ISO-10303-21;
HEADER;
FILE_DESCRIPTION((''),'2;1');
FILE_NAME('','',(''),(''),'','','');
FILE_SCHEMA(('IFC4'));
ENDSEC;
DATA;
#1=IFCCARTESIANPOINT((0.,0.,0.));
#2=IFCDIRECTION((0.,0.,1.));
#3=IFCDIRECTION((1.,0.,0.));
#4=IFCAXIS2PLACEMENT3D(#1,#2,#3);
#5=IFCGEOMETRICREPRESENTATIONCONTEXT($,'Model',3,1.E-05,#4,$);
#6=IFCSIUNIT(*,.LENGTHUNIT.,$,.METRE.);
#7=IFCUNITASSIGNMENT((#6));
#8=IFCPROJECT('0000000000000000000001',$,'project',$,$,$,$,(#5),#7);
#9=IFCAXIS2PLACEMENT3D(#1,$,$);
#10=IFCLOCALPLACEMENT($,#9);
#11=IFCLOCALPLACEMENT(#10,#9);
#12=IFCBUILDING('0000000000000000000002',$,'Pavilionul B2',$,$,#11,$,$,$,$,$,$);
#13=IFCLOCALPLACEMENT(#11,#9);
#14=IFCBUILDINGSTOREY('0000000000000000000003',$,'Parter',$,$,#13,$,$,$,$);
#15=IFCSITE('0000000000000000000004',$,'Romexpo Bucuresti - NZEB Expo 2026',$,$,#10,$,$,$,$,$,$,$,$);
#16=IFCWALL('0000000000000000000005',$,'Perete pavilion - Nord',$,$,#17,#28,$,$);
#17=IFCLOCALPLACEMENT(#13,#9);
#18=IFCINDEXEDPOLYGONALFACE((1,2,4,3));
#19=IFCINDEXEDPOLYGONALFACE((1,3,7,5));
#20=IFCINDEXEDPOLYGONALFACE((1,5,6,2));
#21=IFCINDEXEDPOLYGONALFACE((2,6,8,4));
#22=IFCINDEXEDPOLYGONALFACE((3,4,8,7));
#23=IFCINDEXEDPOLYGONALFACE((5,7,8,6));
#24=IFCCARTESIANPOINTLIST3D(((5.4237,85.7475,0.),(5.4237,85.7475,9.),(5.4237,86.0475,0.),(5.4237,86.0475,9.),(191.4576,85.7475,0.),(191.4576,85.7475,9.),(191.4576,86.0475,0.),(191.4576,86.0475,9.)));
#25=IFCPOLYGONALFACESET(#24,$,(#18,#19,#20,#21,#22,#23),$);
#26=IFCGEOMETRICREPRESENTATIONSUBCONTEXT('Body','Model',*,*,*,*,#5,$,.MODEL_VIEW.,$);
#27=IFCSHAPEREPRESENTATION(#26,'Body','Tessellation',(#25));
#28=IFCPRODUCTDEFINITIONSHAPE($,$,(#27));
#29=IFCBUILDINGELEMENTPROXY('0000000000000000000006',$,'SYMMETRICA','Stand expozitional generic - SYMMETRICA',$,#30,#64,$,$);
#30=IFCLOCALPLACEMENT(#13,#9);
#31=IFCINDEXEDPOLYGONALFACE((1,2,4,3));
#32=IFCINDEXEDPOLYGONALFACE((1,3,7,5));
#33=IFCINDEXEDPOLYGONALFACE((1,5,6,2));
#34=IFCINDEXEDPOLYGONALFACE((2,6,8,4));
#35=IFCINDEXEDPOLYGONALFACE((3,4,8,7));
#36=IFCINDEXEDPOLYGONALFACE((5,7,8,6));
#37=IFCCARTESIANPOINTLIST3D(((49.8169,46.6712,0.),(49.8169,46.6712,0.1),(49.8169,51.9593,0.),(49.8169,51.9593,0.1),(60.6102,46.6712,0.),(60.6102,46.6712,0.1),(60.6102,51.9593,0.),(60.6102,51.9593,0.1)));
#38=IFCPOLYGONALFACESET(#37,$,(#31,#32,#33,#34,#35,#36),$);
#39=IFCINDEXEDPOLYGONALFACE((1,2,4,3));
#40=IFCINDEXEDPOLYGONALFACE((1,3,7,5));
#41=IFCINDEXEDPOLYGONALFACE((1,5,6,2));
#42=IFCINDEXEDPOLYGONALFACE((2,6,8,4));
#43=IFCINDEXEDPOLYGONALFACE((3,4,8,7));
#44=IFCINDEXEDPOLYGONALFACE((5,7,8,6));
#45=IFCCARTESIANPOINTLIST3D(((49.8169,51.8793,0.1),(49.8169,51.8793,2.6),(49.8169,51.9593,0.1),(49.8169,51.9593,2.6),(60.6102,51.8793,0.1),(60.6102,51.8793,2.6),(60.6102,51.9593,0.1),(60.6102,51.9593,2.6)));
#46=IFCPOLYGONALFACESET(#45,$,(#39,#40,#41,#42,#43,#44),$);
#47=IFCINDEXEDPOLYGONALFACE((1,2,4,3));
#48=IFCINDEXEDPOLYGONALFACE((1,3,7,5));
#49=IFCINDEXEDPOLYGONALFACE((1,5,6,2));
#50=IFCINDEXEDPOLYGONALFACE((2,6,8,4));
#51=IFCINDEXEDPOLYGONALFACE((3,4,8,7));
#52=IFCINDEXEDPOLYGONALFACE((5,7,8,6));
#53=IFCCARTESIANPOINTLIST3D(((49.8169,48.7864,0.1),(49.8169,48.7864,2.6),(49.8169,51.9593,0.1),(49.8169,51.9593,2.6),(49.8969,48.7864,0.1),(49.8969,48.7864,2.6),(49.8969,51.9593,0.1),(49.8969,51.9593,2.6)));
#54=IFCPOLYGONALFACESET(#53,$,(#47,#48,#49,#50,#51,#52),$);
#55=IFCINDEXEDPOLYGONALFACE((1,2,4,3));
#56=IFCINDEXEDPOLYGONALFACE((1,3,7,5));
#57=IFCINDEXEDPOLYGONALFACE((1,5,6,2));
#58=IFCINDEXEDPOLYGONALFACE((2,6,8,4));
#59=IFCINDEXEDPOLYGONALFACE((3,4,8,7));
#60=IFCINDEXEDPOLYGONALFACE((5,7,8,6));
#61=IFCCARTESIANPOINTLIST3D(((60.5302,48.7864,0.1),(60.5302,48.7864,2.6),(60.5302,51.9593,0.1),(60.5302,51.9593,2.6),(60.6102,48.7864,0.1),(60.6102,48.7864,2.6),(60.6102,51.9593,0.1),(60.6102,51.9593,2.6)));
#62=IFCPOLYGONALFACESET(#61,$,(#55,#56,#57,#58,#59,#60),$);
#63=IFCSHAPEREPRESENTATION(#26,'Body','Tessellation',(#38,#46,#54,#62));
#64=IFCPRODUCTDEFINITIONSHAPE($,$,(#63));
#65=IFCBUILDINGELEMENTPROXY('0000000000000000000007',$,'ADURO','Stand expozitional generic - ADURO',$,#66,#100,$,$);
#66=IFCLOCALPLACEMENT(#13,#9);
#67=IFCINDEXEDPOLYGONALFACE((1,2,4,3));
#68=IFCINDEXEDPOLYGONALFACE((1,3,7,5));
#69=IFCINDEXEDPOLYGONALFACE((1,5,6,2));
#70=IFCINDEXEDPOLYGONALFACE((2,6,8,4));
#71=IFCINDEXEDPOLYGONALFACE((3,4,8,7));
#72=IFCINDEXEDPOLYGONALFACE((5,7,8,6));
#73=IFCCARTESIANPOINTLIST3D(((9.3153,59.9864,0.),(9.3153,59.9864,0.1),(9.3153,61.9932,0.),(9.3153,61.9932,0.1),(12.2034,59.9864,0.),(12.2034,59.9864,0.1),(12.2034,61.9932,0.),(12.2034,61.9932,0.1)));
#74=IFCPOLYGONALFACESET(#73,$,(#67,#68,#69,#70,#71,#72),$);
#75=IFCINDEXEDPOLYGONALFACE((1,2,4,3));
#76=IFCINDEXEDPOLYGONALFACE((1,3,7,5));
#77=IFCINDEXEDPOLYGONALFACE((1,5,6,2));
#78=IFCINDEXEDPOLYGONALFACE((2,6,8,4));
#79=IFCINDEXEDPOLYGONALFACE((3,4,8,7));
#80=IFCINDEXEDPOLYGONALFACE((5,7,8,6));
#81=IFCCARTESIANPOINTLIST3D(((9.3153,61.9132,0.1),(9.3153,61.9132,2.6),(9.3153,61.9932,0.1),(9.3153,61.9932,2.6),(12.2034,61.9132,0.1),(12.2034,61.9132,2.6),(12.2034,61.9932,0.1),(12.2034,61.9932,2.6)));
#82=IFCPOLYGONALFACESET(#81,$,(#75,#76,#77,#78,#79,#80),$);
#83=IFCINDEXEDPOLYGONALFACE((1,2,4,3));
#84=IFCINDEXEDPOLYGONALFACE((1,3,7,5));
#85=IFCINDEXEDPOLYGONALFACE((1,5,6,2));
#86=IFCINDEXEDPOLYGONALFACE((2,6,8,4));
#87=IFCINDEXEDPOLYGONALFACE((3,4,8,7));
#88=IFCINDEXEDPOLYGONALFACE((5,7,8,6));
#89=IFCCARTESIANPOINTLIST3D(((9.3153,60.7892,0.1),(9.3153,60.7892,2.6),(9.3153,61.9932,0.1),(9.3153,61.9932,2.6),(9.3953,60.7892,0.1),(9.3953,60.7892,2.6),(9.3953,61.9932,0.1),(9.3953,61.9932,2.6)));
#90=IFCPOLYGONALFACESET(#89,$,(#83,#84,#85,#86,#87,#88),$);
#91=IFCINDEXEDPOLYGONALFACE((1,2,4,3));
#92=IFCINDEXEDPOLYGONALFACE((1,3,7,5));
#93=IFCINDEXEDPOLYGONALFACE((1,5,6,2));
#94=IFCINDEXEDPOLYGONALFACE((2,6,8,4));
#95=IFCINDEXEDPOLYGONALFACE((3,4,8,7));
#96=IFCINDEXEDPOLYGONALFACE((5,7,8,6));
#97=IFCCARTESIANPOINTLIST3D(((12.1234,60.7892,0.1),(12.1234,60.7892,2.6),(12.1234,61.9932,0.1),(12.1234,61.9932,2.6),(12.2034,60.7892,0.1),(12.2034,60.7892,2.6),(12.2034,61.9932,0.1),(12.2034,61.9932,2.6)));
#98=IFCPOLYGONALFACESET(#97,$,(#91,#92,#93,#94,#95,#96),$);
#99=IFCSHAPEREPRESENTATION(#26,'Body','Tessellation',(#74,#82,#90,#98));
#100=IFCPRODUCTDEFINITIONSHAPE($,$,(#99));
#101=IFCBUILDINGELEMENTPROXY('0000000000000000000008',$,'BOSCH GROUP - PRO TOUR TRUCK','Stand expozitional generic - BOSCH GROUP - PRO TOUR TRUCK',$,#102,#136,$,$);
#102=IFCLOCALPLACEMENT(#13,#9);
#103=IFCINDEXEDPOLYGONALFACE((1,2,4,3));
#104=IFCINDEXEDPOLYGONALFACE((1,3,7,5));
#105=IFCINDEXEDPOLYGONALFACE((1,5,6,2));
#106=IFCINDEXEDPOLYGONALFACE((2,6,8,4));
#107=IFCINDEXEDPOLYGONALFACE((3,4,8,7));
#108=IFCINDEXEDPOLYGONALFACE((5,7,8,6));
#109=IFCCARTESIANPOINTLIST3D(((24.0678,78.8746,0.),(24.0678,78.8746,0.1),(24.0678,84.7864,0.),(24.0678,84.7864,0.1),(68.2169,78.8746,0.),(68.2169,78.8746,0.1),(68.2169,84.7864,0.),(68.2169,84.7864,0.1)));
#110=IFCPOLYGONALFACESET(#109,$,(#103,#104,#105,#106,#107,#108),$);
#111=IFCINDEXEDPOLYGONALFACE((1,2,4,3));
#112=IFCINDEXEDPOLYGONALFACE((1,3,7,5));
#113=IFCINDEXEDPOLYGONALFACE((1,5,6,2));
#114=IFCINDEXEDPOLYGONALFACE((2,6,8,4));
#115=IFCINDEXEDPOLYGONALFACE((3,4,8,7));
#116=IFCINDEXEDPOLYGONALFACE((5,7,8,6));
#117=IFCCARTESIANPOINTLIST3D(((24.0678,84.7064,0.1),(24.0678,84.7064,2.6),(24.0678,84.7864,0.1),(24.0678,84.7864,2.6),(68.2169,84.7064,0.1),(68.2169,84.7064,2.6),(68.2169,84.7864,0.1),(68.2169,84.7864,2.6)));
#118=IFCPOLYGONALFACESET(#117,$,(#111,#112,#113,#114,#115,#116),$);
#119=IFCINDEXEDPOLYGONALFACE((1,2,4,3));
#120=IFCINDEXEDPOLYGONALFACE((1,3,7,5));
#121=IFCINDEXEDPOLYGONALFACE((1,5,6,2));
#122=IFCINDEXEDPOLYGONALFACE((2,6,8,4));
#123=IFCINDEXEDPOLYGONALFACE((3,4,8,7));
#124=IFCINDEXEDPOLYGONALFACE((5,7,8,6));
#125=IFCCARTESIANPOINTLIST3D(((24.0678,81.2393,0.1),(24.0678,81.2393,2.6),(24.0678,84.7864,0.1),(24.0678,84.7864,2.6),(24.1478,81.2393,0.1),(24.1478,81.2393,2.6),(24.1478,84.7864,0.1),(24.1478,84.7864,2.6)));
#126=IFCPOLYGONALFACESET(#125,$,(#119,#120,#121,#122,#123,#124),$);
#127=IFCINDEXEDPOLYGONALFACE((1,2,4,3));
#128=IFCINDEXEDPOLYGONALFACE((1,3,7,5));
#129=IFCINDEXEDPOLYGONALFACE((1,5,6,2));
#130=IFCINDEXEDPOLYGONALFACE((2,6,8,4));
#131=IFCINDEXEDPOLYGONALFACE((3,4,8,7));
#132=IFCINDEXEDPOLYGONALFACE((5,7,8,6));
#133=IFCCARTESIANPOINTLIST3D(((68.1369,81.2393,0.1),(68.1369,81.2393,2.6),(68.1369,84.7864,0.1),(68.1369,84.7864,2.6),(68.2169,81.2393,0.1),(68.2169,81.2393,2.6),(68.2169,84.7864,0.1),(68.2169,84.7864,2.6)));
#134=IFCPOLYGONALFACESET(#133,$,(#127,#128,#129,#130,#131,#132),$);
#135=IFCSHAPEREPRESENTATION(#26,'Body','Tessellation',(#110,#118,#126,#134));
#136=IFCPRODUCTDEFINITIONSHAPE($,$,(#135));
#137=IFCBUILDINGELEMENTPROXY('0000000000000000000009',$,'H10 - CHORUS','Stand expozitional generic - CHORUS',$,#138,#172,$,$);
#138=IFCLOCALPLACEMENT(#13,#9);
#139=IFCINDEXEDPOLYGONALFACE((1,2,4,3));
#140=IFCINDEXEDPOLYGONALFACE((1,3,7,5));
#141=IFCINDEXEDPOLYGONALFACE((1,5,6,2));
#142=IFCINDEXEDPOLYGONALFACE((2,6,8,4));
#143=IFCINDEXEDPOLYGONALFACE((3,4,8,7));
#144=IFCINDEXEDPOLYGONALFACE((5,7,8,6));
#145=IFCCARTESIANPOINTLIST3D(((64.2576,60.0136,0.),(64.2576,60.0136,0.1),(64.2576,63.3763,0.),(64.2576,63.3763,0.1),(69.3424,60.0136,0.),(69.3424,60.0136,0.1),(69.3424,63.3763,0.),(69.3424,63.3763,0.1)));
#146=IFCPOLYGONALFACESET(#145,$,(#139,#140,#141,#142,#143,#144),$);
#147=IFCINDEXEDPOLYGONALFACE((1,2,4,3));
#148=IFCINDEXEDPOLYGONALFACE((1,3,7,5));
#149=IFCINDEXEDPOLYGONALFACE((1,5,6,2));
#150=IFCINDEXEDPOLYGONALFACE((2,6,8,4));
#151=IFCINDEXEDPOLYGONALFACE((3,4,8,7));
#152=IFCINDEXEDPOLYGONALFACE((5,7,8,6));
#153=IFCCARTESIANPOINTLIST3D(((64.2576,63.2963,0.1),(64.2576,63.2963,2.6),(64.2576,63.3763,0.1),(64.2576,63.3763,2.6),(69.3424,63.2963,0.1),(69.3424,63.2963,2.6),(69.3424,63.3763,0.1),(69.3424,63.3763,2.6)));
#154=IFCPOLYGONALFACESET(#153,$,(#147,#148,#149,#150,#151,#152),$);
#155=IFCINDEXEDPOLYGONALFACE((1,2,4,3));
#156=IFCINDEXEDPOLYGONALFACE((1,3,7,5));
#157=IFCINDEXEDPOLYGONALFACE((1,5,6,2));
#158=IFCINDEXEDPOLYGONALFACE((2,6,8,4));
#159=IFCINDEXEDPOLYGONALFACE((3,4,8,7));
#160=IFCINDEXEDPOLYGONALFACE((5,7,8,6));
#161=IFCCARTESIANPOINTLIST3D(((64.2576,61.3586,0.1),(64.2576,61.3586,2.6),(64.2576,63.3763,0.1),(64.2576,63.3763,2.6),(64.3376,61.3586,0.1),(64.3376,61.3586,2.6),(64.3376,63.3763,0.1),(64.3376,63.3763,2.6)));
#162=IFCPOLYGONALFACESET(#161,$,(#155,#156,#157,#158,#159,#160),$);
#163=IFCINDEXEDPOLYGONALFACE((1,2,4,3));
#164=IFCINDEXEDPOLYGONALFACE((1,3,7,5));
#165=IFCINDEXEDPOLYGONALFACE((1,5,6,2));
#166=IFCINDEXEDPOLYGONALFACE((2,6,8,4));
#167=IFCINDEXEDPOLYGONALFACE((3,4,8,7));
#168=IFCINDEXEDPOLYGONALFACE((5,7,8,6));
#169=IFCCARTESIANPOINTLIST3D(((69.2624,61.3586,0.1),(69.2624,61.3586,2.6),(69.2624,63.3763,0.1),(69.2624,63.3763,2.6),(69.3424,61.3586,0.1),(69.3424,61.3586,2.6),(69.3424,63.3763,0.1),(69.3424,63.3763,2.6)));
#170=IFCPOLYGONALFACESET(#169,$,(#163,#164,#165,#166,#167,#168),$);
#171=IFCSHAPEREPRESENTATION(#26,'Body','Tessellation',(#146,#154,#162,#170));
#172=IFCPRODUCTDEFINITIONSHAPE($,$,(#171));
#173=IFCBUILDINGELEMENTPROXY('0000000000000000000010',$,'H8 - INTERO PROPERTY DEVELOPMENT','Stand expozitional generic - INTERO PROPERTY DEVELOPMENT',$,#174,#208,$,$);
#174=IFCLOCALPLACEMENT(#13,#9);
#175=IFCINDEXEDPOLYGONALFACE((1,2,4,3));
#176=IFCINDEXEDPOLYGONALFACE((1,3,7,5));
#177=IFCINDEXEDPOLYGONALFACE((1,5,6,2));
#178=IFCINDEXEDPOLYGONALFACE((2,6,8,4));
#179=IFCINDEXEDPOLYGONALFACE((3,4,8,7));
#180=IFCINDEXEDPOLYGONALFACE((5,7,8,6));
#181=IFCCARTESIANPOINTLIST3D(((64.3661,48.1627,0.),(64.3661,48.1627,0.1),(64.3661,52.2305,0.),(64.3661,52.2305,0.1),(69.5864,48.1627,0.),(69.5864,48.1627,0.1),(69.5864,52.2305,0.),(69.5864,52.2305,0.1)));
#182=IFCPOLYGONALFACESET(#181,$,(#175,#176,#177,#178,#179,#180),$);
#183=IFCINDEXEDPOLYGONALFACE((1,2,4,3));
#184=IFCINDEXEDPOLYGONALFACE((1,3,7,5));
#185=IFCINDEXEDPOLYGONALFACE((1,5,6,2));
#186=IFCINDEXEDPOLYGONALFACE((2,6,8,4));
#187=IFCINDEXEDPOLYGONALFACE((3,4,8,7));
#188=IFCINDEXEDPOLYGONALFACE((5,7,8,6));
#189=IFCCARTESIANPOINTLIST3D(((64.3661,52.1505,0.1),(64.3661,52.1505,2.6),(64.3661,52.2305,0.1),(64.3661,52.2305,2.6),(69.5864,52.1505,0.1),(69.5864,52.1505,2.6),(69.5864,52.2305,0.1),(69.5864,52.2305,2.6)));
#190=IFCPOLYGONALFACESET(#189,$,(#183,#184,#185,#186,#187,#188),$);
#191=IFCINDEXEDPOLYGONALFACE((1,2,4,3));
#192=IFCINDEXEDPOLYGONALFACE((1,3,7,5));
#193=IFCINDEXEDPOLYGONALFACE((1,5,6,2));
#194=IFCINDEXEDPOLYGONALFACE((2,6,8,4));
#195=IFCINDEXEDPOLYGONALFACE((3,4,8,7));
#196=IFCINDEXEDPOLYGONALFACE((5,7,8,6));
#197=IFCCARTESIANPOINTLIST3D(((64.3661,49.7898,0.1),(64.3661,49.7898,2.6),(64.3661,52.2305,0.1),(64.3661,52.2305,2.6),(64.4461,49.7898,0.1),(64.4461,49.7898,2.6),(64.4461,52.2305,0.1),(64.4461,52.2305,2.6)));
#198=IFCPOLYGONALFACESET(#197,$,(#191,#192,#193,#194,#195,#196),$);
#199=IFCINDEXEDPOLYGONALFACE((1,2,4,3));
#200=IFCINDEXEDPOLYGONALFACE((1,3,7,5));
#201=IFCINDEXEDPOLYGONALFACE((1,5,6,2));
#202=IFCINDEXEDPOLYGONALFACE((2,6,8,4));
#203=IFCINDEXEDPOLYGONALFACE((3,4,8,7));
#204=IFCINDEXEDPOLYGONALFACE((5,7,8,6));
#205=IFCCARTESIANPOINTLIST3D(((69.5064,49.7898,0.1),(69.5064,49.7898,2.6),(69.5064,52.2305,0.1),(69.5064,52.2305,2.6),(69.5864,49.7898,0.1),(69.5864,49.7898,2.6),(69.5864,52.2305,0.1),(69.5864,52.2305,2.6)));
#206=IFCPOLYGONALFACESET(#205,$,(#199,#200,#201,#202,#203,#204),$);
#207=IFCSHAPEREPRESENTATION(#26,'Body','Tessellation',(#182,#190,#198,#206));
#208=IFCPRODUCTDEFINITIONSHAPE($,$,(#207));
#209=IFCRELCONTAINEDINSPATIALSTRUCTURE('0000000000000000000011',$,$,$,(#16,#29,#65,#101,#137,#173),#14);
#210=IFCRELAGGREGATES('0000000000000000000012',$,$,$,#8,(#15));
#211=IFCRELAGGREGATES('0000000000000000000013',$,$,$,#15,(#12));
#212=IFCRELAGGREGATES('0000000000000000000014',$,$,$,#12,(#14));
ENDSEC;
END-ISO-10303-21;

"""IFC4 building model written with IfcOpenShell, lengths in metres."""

from ifc_helpers import new_model, si_unit, frame, frame_2d, origin, origin_with_axes, place, context, subcontext, project, spatial, rectangle, extrude, element, save


model = new_model("IFC4")

# Units and contexts
model_context = context("Model", 3, precision=1e-05, world=origin_with_axes())
body_context = subcontext(model_context, "Body", "Model", "MODEL_VIEW")
ifc_project = project(units=[si_unit("LENGTHUNIT", "METRE")], contexts=[model_context])

# Site, building, storey
site_placement = place(None, origin())
site = spatial("IfcSite", under=ifc_project, at=site_placement, Name="Romexpo Bucuresti - NZEB Expo 2026")
building_placement = place(site_placement, origin())
building = spatial("IfcBuilding", under=site, at=building_placement, Name="Pavilionul B2")
storey_placement = place(building_placement, origin())
storey = spatial("IfcBuildingStorey", under=building, at=storey_placement, Name="Parter")

# Wall
wall_placement = place(storey_placement, frame((5.4237, 85.7475, 0.0), z_axis=(0.0, 0.0, 1.0), x_axis=(1.0, 0.0, 0.0)))
element("IfcWall", 1, at=wall_placement, inside=storey, Name="Perete pavilion - Nord", context=body_context, shape_type="SweptSolid", body=[
    extrude(rectangle(XDim=186.0339, YDim=0.3, at=frame_2d((93.0169, 0.15))), origin(), (0.0, 0.0, 1.0), 9.0),
])

# Building element proxies
proxy_1_placement = place(storey_placement, frame((49.8169, 46.6712, 0.0), z_axis=(0.0, 0.0, 1.0), x_axis=(1.0, 0.0, 0.0)))
element("IfcBuildingElementProxy", 2, at=proxy_1_placement, inside=storey, Name="SYMMETRICA", Description="Stand expozitional generic - SYMMETRICA", context=body_context, shape_type="SweptSolid", body=[
    extrude(rectangle(XDim=10.7932, YDim=5.2881, at=frame_2d((5.3966, 2.6441))), origin(), (0.0, 0.0, 1.0), 0.1),
    extrude(rectangle(XDim=10.7932, YDim=0.08, at=frame_2d((5.3966, 5.2481))), frame((0.0, 0.0, 0.1)), (0.0, 0.0, 1.0), 2.5),
    extrude(rectangle(XDim=0.08, YDim=3.1729, at=frame_2d((0.04, 3.7017))), frame((0.0, 0.0, 0.1)), (0.0, 0.0, 1.0), 2.5),
    extrude(rectangle(XDim=0.08, YDim=3.1729, at=frame_2d((10.7532, 3.7017))), frame((0.0, 0.0, 0.1)), (0.0, 0.0, 1.0), 2.5),
])
proxy_2_placement = place(storey_placement, frame((9.3153, 59.9864, 0.0), z_axis=(0.0, 0.0, 1.0), x_axis=(1.0, 0.0, 0.0)))
element("IfcBuildingElementProxy", 3, at=proxy_2_placement, inside=storey, Name="ADURO", Description="Stand expozitional generic - ADURO", context=body_context, shape_type="SweptSolid", body=[
    extrude(rectangle(XDim=2.8881, YDim=2.0068, at=frame_2d((1.4441, 1.0034))), origin(), (0.0, 0.0, 1.0), 0.1),
    extrude(rectangle(XDim=2.8881, YDim=0.08, at=frame_2d((1.4441, 1.9668))), frame((0.0, 0.0, 0.1)), (0.0, 0.0, 1.0), 2.5),
    extrude(rectangle(XDim=0.08, YDim=1.2041, at=frame_2d((0.04, 1.4047))), frame((0.0, 0.0, 0.1)), (0.0, 0.0, 1.0), 2.5),
    extrude(rectangle(XDim=0.08, YDim=1.2041, at=frame_2d((2.8481, 1.4047))), frame((0.0, 0.0, 0.1)), (0.0, 0.0, 1.0), 2.5),
])
proxy_3_placement = place(storey_placement, frame((24.0678, 78.8746, 0.0), z_axis=(0.0, 0.0, 1.0), x_axis=(1.0, 0.0, 0.0)))
element("IfcBuildingElementProxy", 4, at=proxy_3_placement, inside=storey, Name="BOSCH GROUP - PRO TOUR TRUCK", Description="Stand expozitional generic - BOSCH GROUP - PRO TOUR TRUCK", context=body_context, shape_type="SweptSolid", body=[
    extrude(rectangle(XDim=44.1492, YDim=5.9119, at=frame_2d((22.0746, 2.9559))), origin(), (0.0, 0.0, 1.0), 0.1),
    extrude(rectangle(XDim=44.1492, YDim=0.08, at=frame_2d((22.0746, 5.8719))), frame((0.0, 0.0, 0.1)), (0.0, 0.0, 1.0), 2.5),
    extrude(rectangle(XDim=0.08, YDim=3.5471, at=frame_2d((0.04, 4.1383))), frame((0.0, 0.0, 0.1)), (0.0, 0.0, 1.0), 2.5),
    extrude(rectangle(XDim=0.08, YDim=3.5471, at=frame_2d((44.1092, 4.1383))), frame((0.0, 0.0, 0.1)), (0.0, 0.0, 1.0), 2.5),
])
proxy_4_placement = place(storey_placement, frame((64.2576, 60.0136, 0.0), z_axis=(0.0, 0.0, 1.0), x_axis=(1.0, 0.0, 0.0)))
element("IfcBuildingElementProxy", 5, at=proxy_4_placement, inside=storey, Name="H10 - CHORUS", Description="Stand expozitional generic - CHORUS", context=body_context, shape_type="SweptSolid", body=[
    extrude(rectangle(XDim=5.0847, YDim=3.3627, at=frame_2d((2.5424, 1.6814))), origin(), (0.0, 0.0, 1.0), 0.1),
    extrude(rectangle(XDim=5.0847, YDim=0.08, at=frame_2d((2.5424, 3.3227))), frame((0.0, 0.0, 0.1)), (0.0, 0.0, 1.0), 2.5),
    extrude(rectangle(XDim=0.08, YDim=2.0176, at=frame_2d((0.04, 2.3539))), frame((0.0, 0.0, 0.1)), (0.0, 0.0, 1.0), 2.5),
    extrude(rectangle(XDim=0.08, YDim=2.0176, at=frame_2d((5.0447, 2.3539))), frame((0.0, 0.0, 0.1)), (0.0, 0.0, 1.0), 2.5),
])
proxy_5_placement = place(storey_placement, frame((64.3661, 48.1627, 0.0), z_axis=(0.0, 0.0, 1.0), x_axis=(1.0, 0.0, 0.0)))
element("IfcBuildingElementProxy", 6, at=proxy_5_placement, inside=storey, Name="H8 - INTERO PROPERTY DEVELOPMENT", Description="Stand expozitional generic - INTERO PROPERTY DEVELOPMENT", context=body_context, shape_type="SweptSolid", body=[
    extrude(rectangle(XDim=5.2203, YDim=4.0678, at=frame_2d((2.6102, 2.0339))), origin(), (0.0, 0.0, 1.0), 0.1),
    extrude(rectangle(XDim=5.2203, YDim=0.08, at=frame_2d((2.6102, 4.0278))), frame((0.0, 0.0, 0.1)), (0.0, 0.0, 1.0), 2.5),
    extrude(rectangle(XDim=0.08, YDim=2.4407, at=frame_2d((0.04, 2.8475))), frame((0.0, 0.0, 0.1)), (0.0, 0.0, 1.0), 2.5),
    extrude(rectangle(XDim=0.08, YDim=2.4407, at=frame_2d((5.1803, 2.8475))), frame((0.0, 0.0, 0.1)), (0.0, 0.0, 1.0), 2.5),
])

save(model, "model.ifc")
